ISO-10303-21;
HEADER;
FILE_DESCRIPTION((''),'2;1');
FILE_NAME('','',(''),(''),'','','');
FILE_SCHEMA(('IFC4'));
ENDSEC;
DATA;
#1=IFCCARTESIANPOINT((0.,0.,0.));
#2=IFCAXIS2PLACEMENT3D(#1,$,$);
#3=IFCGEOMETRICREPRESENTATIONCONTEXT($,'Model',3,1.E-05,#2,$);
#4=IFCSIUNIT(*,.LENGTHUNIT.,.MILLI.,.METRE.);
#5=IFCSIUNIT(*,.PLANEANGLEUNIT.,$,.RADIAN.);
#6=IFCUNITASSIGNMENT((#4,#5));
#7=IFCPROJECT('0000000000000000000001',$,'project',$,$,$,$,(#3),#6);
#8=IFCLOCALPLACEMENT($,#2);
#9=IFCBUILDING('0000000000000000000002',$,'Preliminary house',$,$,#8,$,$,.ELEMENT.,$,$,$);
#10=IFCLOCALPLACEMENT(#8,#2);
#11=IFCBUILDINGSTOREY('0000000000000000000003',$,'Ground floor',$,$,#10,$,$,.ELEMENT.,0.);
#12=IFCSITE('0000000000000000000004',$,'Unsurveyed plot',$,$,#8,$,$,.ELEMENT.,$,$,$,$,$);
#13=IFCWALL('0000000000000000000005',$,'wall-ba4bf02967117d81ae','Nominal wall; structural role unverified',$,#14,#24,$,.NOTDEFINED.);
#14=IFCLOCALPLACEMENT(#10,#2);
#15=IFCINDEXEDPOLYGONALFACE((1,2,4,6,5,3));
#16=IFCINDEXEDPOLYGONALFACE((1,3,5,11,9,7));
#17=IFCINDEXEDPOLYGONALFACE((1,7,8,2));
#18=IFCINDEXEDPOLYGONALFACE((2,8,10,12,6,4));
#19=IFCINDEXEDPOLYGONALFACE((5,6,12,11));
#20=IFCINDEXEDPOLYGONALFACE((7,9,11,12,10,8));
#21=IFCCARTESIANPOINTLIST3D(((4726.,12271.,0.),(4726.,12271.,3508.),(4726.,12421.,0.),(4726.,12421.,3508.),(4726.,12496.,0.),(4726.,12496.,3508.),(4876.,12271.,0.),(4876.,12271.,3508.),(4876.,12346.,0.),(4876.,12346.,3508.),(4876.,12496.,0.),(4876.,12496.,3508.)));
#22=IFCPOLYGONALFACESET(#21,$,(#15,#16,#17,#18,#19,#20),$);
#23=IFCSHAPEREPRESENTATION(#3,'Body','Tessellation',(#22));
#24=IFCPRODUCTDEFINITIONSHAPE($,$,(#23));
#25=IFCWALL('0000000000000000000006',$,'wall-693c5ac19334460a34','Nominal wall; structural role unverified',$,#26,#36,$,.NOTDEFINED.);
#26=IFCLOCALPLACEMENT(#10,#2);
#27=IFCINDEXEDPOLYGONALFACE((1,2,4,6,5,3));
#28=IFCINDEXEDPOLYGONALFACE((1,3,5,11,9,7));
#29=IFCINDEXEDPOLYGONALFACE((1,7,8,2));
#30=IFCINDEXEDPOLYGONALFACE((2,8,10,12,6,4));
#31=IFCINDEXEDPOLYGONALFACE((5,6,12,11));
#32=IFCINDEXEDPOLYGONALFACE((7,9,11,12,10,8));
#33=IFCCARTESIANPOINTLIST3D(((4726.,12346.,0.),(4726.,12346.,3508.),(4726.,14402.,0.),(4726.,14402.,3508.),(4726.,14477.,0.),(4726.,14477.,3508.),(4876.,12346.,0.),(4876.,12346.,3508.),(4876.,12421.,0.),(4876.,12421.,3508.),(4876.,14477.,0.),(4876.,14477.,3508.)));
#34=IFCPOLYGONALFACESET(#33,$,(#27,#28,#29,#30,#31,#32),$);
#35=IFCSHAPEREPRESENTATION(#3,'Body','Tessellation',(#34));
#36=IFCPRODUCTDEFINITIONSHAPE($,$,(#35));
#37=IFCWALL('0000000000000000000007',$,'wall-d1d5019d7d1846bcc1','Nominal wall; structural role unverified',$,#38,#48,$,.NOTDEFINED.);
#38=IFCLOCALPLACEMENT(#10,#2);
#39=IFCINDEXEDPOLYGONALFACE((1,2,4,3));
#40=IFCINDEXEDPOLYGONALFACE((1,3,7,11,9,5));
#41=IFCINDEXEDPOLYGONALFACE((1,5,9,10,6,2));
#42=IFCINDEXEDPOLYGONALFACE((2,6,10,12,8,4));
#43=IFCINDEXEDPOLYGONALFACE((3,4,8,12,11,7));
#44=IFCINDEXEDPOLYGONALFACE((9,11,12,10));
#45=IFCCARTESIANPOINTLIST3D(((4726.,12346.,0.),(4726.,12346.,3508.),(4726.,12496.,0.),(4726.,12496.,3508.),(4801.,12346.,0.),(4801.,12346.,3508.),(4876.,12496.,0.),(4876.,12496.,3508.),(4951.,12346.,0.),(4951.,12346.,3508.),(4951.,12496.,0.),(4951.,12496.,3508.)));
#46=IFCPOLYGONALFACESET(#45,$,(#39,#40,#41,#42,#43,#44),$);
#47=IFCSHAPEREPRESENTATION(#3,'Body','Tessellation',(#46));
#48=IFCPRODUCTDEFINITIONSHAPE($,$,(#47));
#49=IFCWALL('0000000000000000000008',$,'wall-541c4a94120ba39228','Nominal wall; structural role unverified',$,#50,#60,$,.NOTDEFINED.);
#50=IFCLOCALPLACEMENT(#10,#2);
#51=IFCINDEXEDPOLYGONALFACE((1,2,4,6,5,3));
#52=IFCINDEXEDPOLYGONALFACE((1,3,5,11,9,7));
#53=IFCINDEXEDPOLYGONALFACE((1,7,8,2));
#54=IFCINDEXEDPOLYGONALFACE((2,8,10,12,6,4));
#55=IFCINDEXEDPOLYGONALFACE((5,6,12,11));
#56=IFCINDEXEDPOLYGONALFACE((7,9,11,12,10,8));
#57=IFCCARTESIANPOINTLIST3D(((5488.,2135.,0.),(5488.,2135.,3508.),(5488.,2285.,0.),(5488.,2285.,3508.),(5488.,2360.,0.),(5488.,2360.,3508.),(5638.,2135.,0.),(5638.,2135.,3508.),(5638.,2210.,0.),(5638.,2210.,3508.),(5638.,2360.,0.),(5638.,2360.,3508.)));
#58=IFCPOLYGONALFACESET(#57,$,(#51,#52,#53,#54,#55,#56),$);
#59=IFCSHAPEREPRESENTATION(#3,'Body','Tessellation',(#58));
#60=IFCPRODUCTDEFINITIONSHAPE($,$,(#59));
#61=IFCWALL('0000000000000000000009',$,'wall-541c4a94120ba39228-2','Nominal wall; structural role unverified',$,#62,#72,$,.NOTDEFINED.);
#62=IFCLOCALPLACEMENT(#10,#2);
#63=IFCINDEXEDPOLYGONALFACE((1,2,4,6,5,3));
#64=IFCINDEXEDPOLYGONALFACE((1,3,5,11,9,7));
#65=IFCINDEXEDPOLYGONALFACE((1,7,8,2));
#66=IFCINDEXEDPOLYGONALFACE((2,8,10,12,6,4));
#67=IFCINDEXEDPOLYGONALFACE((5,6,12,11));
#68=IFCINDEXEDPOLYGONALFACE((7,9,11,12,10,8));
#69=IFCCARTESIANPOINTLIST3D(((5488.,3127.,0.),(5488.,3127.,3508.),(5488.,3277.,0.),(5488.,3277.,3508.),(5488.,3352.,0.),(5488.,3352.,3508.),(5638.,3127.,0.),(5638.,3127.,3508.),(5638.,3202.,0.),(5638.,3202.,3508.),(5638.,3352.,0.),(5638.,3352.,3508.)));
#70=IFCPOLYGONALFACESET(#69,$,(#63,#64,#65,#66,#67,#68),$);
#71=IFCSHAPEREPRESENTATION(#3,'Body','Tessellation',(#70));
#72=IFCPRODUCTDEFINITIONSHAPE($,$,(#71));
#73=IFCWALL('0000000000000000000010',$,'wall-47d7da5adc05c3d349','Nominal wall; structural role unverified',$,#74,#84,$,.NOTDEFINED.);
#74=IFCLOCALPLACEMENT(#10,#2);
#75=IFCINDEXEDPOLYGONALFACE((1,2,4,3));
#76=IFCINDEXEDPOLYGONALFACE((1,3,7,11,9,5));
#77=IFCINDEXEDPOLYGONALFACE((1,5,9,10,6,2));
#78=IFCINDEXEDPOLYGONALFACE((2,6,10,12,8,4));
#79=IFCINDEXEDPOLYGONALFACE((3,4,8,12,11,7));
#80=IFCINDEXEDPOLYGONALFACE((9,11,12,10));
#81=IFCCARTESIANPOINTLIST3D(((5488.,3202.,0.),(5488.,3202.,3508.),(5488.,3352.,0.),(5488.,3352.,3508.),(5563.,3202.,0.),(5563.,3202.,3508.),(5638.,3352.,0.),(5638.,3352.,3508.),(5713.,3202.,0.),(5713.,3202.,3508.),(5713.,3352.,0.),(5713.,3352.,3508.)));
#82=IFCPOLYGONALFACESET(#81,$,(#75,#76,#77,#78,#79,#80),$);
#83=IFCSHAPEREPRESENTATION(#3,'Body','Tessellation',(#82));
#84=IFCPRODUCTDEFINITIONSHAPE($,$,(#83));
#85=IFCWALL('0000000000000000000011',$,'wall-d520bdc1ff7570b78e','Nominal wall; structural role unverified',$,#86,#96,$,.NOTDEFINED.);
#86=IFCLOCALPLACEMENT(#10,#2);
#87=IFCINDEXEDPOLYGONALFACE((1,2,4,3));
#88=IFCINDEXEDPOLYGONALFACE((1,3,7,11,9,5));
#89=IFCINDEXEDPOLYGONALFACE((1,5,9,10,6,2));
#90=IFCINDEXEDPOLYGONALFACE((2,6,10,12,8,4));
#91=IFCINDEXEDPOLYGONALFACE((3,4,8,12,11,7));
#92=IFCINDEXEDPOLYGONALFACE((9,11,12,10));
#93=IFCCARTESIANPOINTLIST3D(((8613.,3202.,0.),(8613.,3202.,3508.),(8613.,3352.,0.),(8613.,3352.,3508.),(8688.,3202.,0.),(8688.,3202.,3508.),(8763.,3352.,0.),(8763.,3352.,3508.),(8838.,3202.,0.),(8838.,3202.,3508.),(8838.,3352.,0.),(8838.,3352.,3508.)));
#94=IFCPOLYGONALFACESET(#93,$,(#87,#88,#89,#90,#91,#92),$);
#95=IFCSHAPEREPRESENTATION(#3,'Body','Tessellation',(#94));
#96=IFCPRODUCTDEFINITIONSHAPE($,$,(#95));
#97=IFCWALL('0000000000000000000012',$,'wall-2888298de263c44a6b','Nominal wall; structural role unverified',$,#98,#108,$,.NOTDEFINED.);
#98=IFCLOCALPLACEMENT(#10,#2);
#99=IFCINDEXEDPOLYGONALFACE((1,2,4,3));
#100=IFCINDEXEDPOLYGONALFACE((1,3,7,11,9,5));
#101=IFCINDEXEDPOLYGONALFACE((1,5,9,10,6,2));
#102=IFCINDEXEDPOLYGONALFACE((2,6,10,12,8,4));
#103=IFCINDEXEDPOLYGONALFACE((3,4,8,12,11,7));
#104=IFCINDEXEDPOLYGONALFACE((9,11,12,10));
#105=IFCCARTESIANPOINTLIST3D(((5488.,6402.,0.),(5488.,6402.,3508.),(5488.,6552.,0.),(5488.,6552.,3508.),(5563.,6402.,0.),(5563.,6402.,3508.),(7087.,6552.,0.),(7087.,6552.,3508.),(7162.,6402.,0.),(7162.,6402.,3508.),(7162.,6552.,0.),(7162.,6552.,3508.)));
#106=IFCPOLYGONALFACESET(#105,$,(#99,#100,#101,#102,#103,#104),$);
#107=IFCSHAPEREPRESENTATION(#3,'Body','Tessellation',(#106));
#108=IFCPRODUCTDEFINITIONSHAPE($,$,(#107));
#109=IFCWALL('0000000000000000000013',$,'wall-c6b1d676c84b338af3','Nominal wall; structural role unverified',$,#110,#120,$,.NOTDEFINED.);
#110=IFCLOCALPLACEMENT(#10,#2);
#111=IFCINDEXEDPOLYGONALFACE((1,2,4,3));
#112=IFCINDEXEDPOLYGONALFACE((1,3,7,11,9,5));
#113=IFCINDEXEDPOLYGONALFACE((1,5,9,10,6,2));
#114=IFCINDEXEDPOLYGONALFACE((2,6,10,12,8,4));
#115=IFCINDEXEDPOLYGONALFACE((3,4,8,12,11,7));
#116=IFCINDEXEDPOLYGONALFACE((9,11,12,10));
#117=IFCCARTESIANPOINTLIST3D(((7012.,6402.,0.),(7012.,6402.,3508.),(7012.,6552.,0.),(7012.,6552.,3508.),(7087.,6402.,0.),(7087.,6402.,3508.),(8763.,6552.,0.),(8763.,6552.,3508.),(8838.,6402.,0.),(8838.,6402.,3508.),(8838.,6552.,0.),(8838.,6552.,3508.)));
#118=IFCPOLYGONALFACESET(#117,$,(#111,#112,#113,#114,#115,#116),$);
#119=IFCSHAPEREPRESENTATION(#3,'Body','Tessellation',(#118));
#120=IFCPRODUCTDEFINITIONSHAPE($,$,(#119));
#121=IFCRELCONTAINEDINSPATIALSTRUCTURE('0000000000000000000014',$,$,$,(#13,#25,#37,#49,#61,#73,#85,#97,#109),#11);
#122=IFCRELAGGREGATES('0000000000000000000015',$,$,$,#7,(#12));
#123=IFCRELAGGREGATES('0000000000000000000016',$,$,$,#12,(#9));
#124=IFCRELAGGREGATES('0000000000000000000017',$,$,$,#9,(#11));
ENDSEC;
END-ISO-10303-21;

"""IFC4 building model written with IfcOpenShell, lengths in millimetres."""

from ifc_helpers import new_model, si_unit, origin, place, context, project, spatial, polyline, outline, extrude, element, save


model = new_model("IFC4")

# Units and contexts
model_context = context("Model", 3, precision=1e-05, world=origin())
ifc_project = project(units=[si_unit("LENGTHUNIT", "METRE", prefix="MILLI"), si_unit("PLANEANGLEUNIT", "RADIAN")], contexts=[model_context])

# Site, building, storey
placement_1 = place(None, origin())
site = spatial("IfcSite", under=ifc_project, at=placement_1, Name="Unsurveyed plot", CompositionType="ELEMENT")
building = spatial("IfcBuilding", under=site, at=placement_1, Name="Preliminary house", CompositionType="ELEMENT")
placement_2 = place(placement_1, origin())
storey = spatial("IfcBuildingStorey", under=building, at=placement_2, Name="Ground floor", CompositionType="ELEMENT", Elevation=0.0)

# Walls
element("IfcWall", 1, at=placement_2, inside=storey, Name="wall-ba4bf02967117d81ae", Description="Nominal wall; structural role unverified", PredefinedType="NOTDEFINED", context=model_context, shape_type="SweptSolid", body=[
    extrude(outline(polyline([(4726.0, 12421.0), (4726.0, 12496.0), (4876.0, 12496.0), (4876.0, 12346.0), (4876.0, 12271.0), (4726.0, 12271.0), (4726.0, 12421.0)])), origin(), (0.0, 0.0, 1.0), 3508.0),
])
element("IfcWall", 2, at=placement_2, inside=storey, Name="wall-693c5ac19334460a34", Description="Nominal wall; structural role unverified", PredefinedType="NOTDEFINED", context=model_context, shape_type="SweptSolid", body=[
    extrude(outline(polyline([(4726.0, 14402.0), (4726.0, 14477.0), (4876.0, 14477.0), (4876.0, 12421.0), (4876.0, 12346.0), (4726.0, 12346.0), (4726.0, 14402.0)])), origin(), (0.0, 0.0, 1.0), 3508.0),
])
element("IfcWall", 3, at=placement_2, inside=storey, Name="wall-d1d5019d7d1846bcc1", Description="Nominal wall; structural role unverified", PredefinedType="NOTDEFINED", context=model_context, shape_type="SweptSolid", body=[
    extrude(outline(polyline([(4876.0, 12496.0), (4951.0, 12496.0), (4951.0, 12346.0), (4801.0, 12346.0), (4726.0, 12346.0), (4726.0, 12496.0), (4876.0, 12496.0)])), origin(), (0.0, 0.0, 1.0), 3508.0),
])

# Wall
element("IfcWall", 4, at=placement_2, inside=storey, Name="wall-541c4a94120ba39228", Description="Nominal wall; structural role unverified", PredefinedType="NOTDEFINED", context=model_context, shape_type="SweptSolid", body=[
    extrude(outline(polyline([(5488.0, 2285.0), (5488.0, 2360.0), (5638.0, 2360.0), (5638.0, 2210.0), (5638.0, 2135.0), (5488.0, 2135.0), (5488.0, 2285.0)])), origin(), (0.0, 0.0, 1.0), 3508.0),
])

# Wall
element("IfcWall", 5, at=placement_2, inside=storey, Name="wall-541c4a94120ba39228-2", Description="Nominal wall; structural role unverified", PredefinedType="NOTDEFINED", context=model_context, shape_type="SweptSolid", body=[
    extrude(outline(polyline([(5488.0, 3277.0), (5488.0, 3352.0), (5638.0, 3352.0), (5638.0, 3202.0), (5638.0, 3127.0), (5488.0, 3127.0), (5488.0, 3277.0)])), origin(), (0.0, 0.0, 1.0), 3508.0),
])

# Wall
element("IfcWall", 6, at=placement_2, inside=storey, Name="wall-47d7da5adc05c3d349", Description="Nominal wall; structural role unverified", PredefinedType="NOTDEFINED", context=model_context, shape_type="SweptSolid", body=[
    extrude(outline(polyline([(5638.0, 3352.0), (5713.0, 3352.0), (5713.0, 3202.0), (5563.0, 3202.0), (5488.0, 3202.0), (5488.0, 3352.0), (5638.0, 3352.0)])), origin(), (0.0, 0.0, 1.0), 3508.0),
])

# Walls
element("IfcWall", 7, at=placement_2, inside=storey, Name="wall-d520bdc1ff7570b78e", Description="Nominal wall; structural role unverified", PredefinedType="NOTDEFINED", context=model_context, shape_type="SweptSolid", body=[
    extrude(outline(polyline([(8763.0, 3352.0), (8838.0, 3352.0), (8838.0, 3202.0), (8688.0, 3202.0), (8613.0, 3202.0), (8613.0, 3352.0), (8763.0, 3352.0)])), origin(), (0.0, 0.0, 1.0), 3508.0),
])
element("IfcWall", 8, at=placement_2, inside=storey, Name="wall-2888298de263c44a6b", Description="Nominal wall; structural role unverified", PredefinedType="NOTDEFINED", context=model_context, shape_type="SweptSolid", body=[
    extrude(outline(polyline([(7087.0, 6552.0), (7162.0, 6552.0), (7162.0, 6402.0), (5563.0, 6402.0), (5488.0, 6402.0), (5488.0, 6552.0), (7087.0, 6552.0)])), origin(), (0.0, 0.0, 1.0), 3508.0),
])

# Wall
element("IfcWall", 9, at=placement_2, inside=storey, Name="wall-c6b1d676c84b338af3", Description="Nominal wall; structural role unverified", PredefinedType="NOTDEFINED", context=model_context, shape_type="SweptSolid", body=[
    extrude(outline(polyline([(8763.0, 6552.0), (8838.0, 6552.0), (8838.0, 6402.0), (7087.0, 6402.0), (7012.0, 6402.0), (7012.0, 6552.0), (8763.0, 6552.0)])), origin(), (0.0, 0.0, 1.0), 3508.0),
])

save(model, "model.ifc")
